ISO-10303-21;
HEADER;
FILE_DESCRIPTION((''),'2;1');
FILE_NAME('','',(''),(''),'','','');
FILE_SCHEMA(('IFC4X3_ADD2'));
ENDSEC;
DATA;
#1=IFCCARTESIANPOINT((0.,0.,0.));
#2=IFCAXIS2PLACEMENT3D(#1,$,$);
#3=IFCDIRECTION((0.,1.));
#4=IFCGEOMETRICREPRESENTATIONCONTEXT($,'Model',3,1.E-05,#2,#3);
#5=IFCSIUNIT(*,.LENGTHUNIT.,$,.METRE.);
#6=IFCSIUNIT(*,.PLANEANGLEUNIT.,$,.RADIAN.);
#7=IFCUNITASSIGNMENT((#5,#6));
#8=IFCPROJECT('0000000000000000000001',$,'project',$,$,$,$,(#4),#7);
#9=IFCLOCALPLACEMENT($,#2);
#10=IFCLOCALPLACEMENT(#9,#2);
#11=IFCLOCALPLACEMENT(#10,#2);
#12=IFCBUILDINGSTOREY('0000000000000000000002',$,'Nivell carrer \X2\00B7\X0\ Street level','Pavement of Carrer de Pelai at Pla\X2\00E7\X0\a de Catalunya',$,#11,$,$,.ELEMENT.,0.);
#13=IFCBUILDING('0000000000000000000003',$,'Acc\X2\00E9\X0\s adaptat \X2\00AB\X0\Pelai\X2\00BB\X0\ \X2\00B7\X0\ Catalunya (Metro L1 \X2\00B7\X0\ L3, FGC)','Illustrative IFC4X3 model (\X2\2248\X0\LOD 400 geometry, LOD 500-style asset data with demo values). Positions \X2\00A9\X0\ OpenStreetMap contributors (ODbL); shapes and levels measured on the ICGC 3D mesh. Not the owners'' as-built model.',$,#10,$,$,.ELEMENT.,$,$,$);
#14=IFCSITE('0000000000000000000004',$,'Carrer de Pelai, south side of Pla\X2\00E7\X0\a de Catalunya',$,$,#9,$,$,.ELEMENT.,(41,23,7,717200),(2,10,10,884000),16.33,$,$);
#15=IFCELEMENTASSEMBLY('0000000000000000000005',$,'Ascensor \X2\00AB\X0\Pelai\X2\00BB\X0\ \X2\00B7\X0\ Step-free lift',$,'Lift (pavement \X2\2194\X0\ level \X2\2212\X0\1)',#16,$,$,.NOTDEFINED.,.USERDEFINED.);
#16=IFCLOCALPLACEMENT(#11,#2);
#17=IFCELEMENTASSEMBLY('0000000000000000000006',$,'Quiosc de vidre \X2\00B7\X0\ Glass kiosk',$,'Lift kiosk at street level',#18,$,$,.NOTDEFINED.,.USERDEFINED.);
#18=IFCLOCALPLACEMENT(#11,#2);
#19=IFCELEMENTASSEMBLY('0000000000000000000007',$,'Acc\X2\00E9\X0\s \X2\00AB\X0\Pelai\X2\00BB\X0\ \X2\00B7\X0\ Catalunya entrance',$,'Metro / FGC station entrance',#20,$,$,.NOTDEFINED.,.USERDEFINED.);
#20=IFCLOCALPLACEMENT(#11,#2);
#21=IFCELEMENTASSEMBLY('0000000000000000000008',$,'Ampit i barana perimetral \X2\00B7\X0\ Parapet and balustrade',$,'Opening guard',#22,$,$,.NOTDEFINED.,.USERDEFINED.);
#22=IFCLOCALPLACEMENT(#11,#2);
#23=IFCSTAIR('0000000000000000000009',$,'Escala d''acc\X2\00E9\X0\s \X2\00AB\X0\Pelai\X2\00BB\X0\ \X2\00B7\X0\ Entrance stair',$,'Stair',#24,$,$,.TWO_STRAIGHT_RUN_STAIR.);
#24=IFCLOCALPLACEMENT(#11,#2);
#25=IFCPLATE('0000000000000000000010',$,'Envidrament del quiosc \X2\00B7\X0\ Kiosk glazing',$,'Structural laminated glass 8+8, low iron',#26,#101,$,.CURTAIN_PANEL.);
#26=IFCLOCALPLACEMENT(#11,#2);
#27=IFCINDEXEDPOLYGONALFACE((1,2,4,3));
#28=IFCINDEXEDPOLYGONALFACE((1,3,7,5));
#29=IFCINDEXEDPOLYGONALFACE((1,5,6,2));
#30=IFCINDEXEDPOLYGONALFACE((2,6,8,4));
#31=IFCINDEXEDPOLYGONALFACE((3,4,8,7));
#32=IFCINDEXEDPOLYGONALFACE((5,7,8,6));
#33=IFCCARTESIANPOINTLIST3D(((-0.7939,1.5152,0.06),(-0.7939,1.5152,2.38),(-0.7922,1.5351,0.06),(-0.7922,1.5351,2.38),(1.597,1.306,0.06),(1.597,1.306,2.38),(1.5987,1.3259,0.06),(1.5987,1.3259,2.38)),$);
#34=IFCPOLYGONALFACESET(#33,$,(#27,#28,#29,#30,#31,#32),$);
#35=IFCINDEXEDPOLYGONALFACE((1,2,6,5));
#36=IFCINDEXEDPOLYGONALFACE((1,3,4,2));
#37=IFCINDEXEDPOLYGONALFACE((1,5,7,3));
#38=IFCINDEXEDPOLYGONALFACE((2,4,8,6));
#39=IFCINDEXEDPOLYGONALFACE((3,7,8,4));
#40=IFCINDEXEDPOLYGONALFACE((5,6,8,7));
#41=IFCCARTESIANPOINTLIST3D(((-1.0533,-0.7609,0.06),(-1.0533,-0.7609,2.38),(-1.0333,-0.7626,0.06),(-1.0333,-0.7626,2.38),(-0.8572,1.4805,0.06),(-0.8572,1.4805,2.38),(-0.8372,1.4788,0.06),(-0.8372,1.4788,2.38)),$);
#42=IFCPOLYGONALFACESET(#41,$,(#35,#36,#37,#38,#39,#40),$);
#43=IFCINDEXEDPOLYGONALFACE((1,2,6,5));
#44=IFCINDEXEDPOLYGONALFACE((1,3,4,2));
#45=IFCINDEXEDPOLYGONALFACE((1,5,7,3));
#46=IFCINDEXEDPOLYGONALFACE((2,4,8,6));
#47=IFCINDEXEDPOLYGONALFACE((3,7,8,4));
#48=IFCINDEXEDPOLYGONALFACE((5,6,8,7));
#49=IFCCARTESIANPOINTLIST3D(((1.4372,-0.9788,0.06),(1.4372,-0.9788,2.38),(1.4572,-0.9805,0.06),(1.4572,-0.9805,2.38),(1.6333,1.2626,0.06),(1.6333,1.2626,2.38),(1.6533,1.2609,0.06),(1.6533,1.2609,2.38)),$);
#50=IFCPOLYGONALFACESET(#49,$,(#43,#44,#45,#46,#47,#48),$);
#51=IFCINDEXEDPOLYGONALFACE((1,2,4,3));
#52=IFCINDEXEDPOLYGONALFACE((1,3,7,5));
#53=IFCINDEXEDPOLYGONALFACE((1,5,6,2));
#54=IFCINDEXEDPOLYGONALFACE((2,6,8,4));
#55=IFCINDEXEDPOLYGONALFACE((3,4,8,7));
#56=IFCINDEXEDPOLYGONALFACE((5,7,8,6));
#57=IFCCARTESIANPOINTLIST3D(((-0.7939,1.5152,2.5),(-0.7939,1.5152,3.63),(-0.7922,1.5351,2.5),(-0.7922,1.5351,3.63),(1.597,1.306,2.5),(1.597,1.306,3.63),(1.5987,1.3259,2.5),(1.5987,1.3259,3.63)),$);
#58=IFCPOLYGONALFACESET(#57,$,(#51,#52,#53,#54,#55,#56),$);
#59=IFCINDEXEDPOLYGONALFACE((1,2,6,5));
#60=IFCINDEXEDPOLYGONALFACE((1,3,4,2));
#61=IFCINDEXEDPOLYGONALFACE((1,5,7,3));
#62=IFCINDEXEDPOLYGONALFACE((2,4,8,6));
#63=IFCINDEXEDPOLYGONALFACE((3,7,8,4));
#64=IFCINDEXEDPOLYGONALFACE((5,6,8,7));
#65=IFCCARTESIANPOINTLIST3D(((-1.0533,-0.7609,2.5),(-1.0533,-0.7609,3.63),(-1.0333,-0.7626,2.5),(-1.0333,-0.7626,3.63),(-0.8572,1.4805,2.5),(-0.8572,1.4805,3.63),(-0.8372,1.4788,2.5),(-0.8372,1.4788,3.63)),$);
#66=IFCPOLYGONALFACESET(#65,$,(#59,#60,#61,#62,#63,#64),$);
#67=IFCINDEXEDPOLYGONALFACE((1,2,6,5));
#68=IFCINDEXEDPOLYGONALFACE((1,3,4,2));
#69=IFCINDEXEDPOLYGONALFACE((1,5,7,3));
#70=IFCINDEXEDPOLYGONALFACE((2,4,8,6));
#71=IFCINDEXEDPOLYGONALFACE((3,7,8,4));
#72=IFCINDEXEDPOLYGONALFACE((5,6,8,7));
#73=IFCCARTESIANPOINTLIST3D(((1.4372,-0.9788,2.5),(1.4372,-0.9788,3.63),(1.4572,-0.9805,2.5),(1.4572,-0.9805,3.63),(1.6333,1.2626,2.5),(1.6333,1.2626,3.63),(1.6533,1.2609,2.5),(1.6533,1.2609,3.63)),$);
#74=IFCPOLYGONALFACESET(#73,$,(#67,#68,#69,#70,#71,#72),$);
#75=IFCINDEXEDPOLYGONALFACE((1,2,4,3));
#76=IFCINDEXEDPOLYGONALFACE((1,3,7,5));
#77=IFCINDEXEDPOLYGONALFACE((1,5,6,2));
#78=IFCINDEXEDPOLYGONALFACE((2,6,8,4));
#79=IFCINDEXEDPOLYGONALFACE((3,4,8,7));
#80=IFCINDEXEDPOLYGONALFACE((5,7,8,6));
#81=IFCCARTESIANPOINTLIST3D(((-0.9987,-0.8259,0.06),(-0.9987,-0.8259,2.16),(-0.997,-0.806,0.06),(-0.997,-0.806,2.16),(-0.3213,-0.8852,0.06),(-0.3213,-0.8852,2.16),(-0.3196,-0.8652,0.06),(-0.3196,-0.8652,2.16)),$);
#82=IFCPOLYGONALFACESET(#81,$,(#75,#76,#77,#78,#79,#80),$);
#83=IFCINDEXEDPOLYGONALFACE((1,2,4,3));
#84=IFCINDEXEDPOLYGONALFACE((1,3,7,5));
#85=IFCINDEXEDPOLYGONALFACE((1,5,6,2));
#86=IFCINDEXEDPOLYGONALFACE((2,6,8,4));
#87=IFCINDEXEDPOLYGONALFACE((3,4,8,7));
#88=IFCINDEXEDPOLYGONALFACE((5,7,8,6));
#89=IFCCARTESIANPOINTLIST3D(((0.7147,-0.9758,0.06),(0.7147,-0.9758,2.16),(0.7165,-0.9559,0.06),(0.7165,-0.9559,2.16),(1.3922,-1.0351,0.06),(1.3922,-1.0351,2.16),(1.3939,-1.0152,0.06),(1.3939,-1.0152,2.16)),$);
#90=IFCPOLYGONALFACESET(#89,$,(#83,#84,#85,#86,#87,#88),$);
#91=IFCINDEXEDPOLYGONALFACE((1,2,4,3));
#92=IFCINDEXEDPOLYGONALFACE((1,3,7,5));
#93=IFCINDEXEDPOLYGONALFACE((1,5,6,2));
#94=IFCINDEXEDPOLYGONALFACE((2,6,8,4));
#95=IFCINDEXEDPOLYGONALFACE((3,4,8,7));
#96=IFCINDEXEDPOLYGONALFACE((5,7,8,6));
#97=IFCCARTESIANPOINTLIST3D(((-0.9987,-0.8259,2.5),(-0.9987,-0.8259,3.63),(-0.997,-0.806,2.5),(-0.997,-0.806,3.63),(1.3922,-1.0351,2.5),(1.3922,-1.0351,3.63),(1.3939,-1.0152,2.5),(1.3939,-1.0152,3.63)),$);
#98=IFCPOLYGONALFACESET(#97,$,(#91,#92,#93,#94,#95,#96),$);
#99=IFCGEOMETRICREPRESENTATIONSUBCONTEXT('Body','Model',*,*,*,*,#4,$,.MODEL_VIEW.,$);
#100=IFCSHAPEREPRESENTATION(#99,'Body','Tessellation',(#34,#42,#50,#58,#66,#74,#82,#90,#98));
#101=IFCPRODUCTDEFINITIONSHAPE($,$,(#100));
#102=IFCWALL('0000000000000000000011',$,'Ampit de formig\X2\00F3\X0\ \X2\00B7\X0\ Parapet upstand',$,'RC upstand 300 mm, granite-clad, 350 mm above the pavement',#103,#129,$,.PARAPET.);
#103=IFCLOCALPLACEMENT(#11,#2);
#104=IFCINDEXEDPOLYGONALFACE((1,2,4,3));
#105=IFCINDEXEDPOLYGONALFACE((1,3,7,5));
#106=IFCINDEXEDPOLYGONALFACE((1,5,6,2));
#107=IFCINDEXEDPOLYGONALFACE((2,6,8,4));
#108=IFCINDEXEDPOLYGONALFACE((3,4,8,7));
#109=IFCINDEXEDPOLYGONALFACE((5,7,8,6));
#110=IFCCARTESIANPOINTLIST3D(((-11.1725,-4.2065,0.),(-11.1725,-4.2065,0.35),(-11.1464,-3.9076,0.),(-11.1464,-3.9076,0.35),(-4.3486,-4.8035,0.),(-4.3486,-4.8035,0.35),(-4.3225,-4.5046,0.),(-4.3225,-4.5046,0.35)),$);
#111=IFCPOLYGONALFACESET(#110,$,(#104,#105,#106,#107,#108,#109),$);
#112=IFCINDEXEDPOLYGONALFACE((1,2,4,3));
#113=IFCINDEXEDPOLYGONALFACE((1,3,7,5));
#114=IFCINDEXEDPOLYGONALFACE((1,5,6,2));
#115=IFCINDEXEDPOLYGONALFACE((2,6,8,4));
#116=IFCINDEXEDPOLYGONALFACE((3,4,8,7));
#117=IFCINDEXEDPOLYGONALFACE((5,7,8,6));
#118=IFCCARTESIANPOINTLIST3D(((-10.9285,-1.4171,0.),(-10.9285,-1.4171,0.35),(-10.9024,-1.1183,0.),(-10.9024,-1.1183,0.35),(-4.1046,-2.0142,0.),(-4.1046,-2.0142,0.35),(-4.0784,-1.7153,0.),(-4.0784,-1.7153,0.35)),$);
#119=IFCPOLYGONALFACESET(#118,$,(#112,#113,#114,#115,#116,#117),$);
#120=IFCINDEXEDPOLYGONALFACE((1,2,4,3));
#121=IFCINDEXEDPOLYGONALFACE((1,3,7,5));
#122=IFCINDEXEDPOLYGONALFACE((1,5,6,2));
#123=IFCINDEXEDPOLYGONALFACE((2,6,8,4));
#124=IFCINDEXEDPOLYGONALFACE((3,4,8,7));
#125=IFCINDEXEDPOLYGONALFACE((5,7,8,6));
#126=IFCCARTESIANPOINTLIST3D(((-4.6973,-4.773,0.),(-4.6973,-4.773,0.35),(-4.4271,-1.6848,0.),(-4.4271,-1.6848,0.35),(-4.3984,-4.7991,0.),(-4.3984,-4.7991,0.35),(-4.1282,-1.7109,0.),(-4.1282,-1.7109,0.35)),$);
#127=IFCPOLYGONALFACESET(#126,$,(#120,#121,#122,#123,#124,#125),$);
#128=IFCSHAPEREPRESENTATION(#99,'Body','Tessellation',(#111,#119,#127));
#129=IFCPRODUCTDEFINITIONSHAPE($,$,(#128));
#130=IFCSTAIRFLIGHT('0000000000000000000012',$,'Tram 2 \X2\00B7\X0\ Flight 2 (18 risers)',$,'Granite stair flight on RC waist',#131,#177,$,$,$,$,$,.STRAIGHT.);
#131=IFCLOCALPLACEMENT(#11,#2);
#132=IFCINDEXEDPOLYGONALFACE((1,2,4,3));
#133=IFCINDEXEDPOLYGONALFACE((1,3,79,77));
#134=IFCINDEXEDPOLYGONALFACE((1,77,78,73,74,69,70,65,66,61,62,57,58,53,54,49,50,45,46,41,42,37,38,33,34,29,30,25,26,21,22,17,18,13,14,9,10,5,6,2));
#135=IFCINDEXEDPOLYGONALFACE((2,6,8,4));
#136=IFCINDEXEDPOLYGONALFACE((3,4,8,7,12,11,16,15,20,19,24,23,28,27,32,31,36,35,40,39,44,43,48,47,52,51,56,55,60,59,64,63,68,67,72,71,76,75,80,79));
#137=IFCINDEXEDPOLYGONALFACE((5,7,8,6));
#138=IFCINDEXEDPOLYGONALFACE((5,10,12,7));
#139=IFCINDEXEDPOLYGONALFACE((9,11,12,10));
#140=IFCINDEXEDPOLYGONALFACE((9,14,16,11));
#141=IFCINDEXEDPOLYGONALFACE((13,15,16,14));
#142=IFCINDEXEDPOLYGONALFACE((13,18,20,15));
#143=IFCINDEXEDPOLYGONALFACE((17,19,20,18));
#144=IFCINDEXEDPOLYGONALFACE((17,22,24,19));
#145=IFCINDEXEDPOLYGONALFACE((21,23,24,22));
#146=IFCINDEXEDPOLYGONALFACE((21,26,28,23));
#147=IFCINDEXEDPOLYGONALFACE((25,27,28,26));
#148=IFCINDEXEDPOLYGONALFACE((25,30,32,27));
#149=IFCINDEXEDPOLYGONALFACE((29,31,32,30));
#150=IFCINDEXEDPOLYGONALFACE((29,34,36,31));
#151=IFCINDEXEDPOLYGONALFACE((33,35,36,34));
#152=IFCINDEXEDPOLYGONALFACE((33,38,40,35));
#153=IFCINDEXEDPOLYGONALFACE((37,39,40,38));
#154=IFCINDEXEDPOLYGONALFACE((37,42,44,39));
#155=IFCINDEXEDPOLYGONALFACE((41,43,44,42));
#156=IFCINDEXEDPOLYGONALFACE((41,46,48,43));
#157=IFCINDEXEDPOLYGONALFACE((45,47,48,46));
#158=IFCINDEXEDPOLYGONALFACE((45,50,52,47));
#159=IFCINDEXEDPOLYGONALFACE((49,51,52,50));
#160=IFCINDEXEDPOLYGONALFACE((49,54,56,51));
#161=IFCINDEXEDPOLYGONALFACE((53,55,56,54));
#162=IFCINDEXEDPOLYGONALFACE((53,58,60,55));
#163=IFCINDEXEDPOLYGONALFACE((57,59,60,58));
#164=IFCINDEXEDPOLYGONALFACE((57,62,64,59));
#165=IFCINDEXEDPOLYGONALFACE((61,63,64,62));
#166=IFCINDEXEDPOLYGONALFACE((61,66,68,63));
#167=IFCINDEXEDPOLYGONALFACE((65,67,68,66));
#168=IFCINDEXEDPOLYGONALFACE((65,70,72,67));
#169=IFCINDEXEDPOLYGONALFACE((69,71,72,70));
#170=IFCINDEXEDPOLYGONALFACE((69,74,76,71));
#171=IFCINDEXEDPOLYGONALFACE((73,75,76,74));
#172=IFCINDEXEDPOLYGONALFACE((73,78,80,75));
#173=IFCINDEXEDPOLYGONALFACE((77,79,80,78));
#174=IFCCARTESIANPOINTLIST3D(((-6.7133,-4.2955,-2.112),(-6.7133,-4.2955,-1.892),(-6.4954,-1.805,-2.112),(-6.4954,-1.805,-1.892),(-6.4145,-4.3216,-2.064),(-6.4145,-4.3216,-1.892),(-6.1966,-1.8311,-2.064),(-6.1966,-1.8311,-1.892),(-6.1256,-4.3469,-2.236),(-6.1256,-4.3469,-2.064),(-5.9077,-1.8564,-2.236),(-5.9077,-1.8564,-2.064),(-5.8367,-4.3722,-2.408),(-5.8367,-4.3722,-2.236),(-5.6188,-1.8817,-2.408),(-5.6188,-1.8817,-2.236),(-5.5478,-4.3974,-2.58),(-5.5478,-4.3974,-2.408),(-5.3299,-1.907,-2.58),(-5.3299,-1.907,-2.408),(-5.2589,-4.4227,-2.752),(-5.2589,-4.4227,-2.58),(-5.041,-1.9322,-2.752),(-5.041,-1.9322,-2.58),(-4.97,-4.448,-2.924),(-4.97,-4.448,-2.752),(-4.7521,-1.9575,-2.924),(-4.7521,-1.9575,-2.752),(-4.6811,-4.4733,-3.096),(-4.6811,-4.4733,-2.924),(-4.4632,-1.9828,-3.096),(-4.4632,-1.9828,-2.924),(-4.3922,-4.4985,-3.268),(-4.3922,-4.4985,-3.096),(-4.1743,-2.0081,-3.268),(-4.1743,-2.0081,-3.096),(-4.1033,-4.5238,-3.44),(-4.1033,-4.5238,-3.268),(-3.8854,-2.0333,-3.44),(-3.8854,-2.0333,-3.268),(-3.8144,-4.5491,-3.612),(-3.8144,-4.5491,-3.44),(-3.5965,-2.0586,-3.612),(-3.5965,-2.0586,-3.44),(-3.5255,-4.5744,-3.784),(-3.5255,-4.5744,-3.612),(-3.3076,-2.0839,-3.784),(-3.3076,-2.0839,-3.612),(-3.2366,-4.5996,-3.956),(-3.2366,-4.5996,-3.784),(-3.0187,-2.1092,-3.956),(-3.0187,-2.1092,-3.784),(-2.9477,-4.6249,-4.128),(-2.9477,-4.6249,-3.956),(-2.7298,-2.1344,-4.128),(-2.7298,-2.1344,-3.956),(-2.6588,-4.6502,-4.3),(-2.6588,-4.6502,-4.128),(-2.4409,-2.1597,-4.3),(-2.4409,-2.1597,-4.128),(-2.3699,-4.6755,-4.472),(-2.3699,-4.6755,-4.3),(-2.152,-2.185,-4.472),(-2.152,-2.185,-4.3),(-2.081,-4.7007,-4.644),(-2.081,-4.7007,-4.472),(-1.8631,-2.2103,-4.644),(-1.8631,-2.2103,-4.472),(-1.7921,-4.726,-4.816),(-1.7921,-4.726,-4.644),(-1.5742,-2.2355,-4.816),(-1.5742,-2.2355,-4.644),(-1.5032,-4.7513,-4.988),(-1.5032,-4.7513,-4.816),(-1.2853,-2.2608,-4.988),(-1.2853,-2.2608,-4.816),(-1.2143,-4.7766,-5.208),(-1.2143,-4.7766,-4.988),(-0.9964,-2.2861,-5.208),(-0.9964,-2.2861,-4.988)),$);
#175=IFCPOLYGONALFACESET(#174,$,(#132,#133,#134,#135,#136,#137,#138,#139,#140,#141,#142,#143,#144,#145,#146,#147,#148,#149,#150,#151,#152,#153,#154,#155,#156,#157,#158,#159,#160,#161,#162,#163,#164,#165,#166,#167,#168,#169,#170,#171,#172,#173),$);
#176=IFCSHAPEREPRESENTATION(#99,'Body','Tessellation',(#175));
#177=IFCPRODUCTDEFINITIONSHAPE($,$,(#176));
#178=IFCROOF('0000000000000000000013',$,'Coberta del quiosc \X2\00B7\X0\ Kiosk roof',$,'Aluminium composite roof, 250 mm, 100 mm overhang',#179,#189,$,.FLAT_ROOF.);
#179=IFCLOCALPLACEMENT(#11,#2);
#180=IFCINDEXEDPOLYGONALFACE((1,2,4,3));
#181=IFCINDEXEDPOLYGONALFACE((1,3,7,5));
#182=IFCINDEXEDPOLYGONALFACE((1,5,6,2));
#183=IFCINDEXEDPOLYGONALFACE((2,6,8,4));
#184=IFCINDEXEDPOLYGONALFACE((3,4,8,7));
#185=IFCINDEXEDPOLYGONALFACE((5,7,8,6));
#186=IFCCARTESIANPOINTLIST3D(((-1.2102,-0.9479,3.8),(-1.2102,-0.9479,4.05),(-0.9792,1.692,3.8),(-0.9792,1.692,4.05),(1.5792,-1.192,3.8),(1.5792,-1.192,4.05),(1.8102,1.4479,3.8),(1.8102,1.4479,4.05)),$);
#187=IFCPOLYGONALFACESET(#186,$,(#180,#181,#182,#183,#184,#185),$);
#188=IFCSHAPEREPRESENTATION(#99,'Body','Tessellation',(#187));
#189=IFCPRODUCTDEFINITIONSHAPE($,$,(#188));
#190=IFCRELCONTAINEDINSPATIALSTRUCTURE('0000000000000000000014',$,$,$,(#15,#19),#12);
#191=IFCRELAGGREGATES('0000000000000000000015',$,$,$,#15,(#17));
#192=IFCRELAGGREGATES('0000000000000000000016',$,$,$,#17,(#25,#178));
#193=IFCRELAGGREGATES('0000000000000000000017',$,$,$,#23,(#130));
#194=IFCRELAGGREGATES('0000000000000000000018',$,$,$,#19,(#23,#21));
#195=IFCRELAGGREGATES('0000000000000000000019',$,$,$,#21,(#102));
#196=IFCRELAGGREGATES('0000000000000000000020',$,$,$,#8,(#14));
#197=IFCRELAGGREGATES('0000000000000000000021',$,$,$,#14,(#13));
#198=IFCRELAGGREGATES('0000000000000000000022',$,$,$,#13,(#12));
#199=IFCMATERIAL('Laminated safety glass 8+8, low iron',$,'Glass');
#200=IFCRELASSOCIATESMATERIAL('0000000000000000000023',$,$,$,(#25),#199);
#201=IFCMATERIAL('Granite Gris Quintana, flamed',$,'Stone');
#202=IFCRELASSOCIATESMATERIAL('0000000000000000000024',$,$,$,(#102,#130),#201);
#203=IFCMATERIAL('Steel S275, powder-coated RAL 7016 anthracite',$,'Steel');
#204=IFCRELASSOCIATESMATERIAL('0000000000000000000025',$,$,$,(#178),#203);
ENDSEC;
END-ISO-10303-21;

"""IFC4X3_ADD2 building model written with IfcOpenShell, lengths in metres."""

from ifc_helpers import new_model, si_unit, direction, frame, frame_2d, origin, place, context, subcontext, project, spatial, polyline, rectangle, outline, extrude, material, element, aggregate, save


model = new_model("IFC4X3_ADD2")

# Units and contexts
model_context = context("Model", 3, precision=1e-05, world=origin(), true_north=direction((0.0, 1.0)))
body_context = subcontext(model_context, "Body", "Model", "MODEL_VIEW")
ifc_project = project(units=[si_unit("LENGTHUNIT", "METRE"), si_unit("PLANEANGLEUNIT", "RADIAN")], contexts=[model_context])

# Site, building, storey
site_placement = place(None, origin())
site = spatial("IfcSite", under=ifc_project, at=site_placement, Name="Carrer de Pelai, south side of Plaça de Catalunya", CompositionType="ELEMENT", RefLatitude=(41, 23, 7, 717200), RefLongitude=(2, 10, 10, 884000), RefElevation=16.33)
building_placement = place(site_placement, origin())
building = spatial("IfcBuilding", under=site, at=building_placement, Name="Accés adaptat «Pelai» · Catalunya (Metro L1 · L3, FGC)", Description="Illustrative IFC4X3 model (≈LOD 400 geometry, LOD 500-style asset data with demo values). Positions © OpenStreetMap contributors (ODbL); shapes and levels measured on the ICGC 3D mesh. Not the owners' as-built model.", CompositionType="ELEMENT")
storey_placement = place(building_placement, origin())
storey = spatial("IfcBuildingStorey", under=building, at=storey_placement, Name="Nivell carrer · Street level", Description="Pavement of Carrer de Pelai at Plaça de Catalunya", CompositionType="ELEMENT", Elevation=0.0)

# Element assemblies
assembly_1_placement = place(building_placement, origin())
assembly_1 = element("IfcElementAssembly", 1, at=assembly_1_placement, inside=storey, Name="Ascensor «Pelai» · Step-free lift", ObjectType="Lift (pavement ↔ level −1)", AssemblyPlace="NOTDEFINED", PredefinedType="USERDEFINED")
assembly_2_placement = place(building_placement, origin())
assembly_2 = element("IfcElementAssembly", 2, at=assembly_2_placement, Name="Quiosc de vidre · Glass kiosk", ObjectType="Lift kiosk at street level", AssemblyPlace="NOTDEFINED", PredefinedType="USERDEFINED")
aggregate(assembly_1, [assembly_2])
ifc_material_1 = material(Name="Steel S275, powder-coated RAL 7016 anthracite", Category="Steel")

# Element assemblies
assembly_3_placement = place(building_placement, origin())
assembly_3 = element("IfcElementAssembly", 3, at=assembly_3_placement, inside=storey, Name="Accés «Pelai» · Catalunya entrance", ObjectType="Metro / FGC station entrance", AssemblyPlace="NOTDEFINED", PredefinedType="USERDEFINED")
assembly_4_placement = place(building_placement, origin())
assembly_4 = element("IfcElementAssembly", 4, at=assembly_4_placement, Name="Ampit i barana perimetral · Parapet and balustrade", ObjectType="Opening guard", AssemblyPlace="NOTDEFINED", PredefinedType="USERDEFINED")

# Stair
stair_placement = place(building_placement, origin())
stair = element("IfcStair", 5, at=stair_placement, Name="Escala d'accés «Pelai» · Entrance stair", ObjectType="Stair", PredefinedType="TWO_STRAIGHT_RUN_STAIR")
ifc_material_2 = material(Name="Granite Gris Quintana, flamed", Category="Stone")

# Plate
ifc_material_3 = material(Name="Laminated safety glass 8+8, low iron", Category="Glass")
plate_placement = place(building_placement, origin())
plate = element("IfcPlate", 6, at=plate_placement, material=ifc_material_3, Name="Envidrament del quiosc · Kiosk glazing", ObjectType="Structural laminated glass 8+8, low iron", PredefinedType="CURTAIN_PANEL", context=body_context, shape_type="SweptSolid", body=[
    extrude(rectangle(XDim=2.4, YDim=0.02, at=frame_2d((0.0, 0.0), x_axis=(0.996195, -0.087156))), frame((0.4024, 1.4205, 0.06)), (0.0, 0.0, 1.0), 2.32),
    extrude(rectangle(XDim=0.02, YDim=2.25, at=frame_2d((0.0, 0.0), x_axis=(0.996195, -0.087156))), frame((-0.9452, 0.3589, 0.06)), (0.0, 0.0, 1.0), 2.32),
    extrude(rectangle(XDim=0.02, YDim=2.25, at=frame_2d((0.0, 0.0), x_axis=(0.996195, -0.087156))), frame((1.5452, 0.1411, 0.06)), (0.0, 0.0, 1.0), 2.32),
    extrude(rectangle(XDim=2.4, YDim=0.02, at=frame_2d((0.0, 0.0), x_axis=(0.996195, -0.087156))), frame((0.4024, 1.4205, 2.5)), (0.0, 0.0, 1.0), 1.13),
    extrude(rectangle(XDim=0.02, YDim=2.25, at=frame_2d((0.0, 0.0), x_axis=(0.996195, -0.087156))), frame((-0.9452, 0.3589, 2.5)), (0.0, 0.0, 1.0), 1.13),
    extrude(rectangle(XDim=0.02, YDim=2.25, at=frame_2d((0.0, 0.0), x_axis=(0.996195, -0.087156))), frame((1.5452, 0.1411, 2.5)), (0.0, 0.0, 1.0), 1.13),
    extrude(rectangle(XDim=0.68, YDim=0.02, at=frame_2d((0.0, 0.0), x_axis=(0.996195, -0.087156))), frame((-0.6591, -0.8456, 0.06)), (0.0, 0.0, 1.0), 2.1),
    extrude(rectangle(XDim=0.68, YDim=0.02, at=frame_2d((0.0, 0.0), x_axis=(0.996195, -0.087156))), frame((1.0543, -0.9955, 0.06)), (0.0, 0.0, 1.0), 2.1),
    extrude(rectangle(XDim=2.4, YDim=0.02, at=frame_2d((0.0, 0.0), x_axis=(0.996195, -0.087156))), frame((0.1976, -0.9205, 2.5)), (0.0, 0.0, 1.0), 1.13),
])

# Wall
wall_1_placement = place(building_placement, origin())
wall_1 = element("IfcWall", 7, at=wall_1_placement, material=ifc_material_2, Name="Ampit de formigó · Parapet upstand", ObjectType="RC upstand 300 mm, granite-clad, 350 mm above the pavement", PredefinedType="PARAPET", context=body_context, shape_type="SweptSolid", body=[
    extrude(rectangle(XDim=6.85, YDim=0.3, at=frame_2d((0.0, 0.0), x_axis=(0.996195, -0.087156))), frame((-7.7475, -4.3556, 0.0)), (0.0, 0.0, 1.0), 0.35),
    extrude(rectangle(XDim=6.85, YDim=0.3, at=frame_2d((0.0, 0.0), x_axis=(0.996195, -0.087156))), frame((-7.5035, -1.5662, 0.0)), (0.0, 0.0, 1.0), 0.35),
    extrude(rectangle(XDim=0.3, YDim=3.1, at=frame_2d((0.0, 0.0), x_axis=(0.996195, -0.087156))), frame((-4.4127, -3.242, 0.0)), (0.0, 0.0, 1.0), 0.35),
])

# Stair flight
stair_flight_1_placement = place(building_placement, origin())
stair_flight_1 = element("IfcStairFlight", 8, at=stair_flight_1_placement, material=ifc_material_2, Name="Tram 2 · Flight 2 (18 risers)", ObjectType="Granite stair flight on RC waist", PredefinedType="STRAIGHT", context=body_context, shape_type="SweptSolid", body=[
    extrude(outline(polyline([(1.15, -1.892), (1.45, -1.892), (1.45, -2.064), (1.74, -2.064), (1.74, -2.236), (2.03, -2.236), (2.03, -2.408), (2.32, -2.408), (2.32, -2.58), (2.61, -2.58), (2.61, -2.752), (2.9, -2.752), (2.9, -2.924), (3.19, -2.924), (3.19, -3.096), (3.48, -3.096), (3.48, -3.268), (3.77, -3.268), (3.77, -3.44), (4.06, -3.44), (4.06, -3.612), (4.35, -3.612), (4.35, -3.784), (4.64, -3.784), (4.64, -3.956), (4.93, -3.956), (4.93, -4.128), (5.22, -4.128), (5.22, -4.3), (5.51, -4.3), (5.51, -4.472), (5.8, -4.472), (5.8, -4.644), (6.09, -4.644), (6.09, -4.816), (6.38, -4.816), (6.38, -4.988), (6.67, -4.988), (6.67, -5.208), (1.15, -2.112), (1.15, -1.892)])), frame((-7.6411, -1.7048, 0.0), z_axis=(-0.087156, -0.996195, 0.0), x_axis=(0.996195, -0.087156, 0.0)), (0.0, 0.0, 1.0), 2.5),
])

# Roof
roof_placement = place(building_placement, origin())
roof = element("IfcRoof", 9, at=roof_placement, material=ifc_material_1, Name="Coberta del quiosc · Kiosk roof", ObjectType="Aluminium composite roof, 250 mm, 100 mm overhang", PredefinedType="FLAT_ROOF", context=body_context, shape_type="SweptSolid", body=[
    extrude(rectangle(XDim=2.8, YDim=2.65, at=frame_2d((0.0, 0.0), x_axis=(0.996195, -0.087156))), frame((0.3, 0.25, 3.8)), (0.0, 0.0, 1.0), 0.25),
])
aggregate(assembly_2, [plate, roof])

aggregate(stair, [stair_flight_1])

aggregate(assembly_3, [stair, assembly_4])

aggregate(assembly_4, [wall_1])

save(model, "model.ifc")
